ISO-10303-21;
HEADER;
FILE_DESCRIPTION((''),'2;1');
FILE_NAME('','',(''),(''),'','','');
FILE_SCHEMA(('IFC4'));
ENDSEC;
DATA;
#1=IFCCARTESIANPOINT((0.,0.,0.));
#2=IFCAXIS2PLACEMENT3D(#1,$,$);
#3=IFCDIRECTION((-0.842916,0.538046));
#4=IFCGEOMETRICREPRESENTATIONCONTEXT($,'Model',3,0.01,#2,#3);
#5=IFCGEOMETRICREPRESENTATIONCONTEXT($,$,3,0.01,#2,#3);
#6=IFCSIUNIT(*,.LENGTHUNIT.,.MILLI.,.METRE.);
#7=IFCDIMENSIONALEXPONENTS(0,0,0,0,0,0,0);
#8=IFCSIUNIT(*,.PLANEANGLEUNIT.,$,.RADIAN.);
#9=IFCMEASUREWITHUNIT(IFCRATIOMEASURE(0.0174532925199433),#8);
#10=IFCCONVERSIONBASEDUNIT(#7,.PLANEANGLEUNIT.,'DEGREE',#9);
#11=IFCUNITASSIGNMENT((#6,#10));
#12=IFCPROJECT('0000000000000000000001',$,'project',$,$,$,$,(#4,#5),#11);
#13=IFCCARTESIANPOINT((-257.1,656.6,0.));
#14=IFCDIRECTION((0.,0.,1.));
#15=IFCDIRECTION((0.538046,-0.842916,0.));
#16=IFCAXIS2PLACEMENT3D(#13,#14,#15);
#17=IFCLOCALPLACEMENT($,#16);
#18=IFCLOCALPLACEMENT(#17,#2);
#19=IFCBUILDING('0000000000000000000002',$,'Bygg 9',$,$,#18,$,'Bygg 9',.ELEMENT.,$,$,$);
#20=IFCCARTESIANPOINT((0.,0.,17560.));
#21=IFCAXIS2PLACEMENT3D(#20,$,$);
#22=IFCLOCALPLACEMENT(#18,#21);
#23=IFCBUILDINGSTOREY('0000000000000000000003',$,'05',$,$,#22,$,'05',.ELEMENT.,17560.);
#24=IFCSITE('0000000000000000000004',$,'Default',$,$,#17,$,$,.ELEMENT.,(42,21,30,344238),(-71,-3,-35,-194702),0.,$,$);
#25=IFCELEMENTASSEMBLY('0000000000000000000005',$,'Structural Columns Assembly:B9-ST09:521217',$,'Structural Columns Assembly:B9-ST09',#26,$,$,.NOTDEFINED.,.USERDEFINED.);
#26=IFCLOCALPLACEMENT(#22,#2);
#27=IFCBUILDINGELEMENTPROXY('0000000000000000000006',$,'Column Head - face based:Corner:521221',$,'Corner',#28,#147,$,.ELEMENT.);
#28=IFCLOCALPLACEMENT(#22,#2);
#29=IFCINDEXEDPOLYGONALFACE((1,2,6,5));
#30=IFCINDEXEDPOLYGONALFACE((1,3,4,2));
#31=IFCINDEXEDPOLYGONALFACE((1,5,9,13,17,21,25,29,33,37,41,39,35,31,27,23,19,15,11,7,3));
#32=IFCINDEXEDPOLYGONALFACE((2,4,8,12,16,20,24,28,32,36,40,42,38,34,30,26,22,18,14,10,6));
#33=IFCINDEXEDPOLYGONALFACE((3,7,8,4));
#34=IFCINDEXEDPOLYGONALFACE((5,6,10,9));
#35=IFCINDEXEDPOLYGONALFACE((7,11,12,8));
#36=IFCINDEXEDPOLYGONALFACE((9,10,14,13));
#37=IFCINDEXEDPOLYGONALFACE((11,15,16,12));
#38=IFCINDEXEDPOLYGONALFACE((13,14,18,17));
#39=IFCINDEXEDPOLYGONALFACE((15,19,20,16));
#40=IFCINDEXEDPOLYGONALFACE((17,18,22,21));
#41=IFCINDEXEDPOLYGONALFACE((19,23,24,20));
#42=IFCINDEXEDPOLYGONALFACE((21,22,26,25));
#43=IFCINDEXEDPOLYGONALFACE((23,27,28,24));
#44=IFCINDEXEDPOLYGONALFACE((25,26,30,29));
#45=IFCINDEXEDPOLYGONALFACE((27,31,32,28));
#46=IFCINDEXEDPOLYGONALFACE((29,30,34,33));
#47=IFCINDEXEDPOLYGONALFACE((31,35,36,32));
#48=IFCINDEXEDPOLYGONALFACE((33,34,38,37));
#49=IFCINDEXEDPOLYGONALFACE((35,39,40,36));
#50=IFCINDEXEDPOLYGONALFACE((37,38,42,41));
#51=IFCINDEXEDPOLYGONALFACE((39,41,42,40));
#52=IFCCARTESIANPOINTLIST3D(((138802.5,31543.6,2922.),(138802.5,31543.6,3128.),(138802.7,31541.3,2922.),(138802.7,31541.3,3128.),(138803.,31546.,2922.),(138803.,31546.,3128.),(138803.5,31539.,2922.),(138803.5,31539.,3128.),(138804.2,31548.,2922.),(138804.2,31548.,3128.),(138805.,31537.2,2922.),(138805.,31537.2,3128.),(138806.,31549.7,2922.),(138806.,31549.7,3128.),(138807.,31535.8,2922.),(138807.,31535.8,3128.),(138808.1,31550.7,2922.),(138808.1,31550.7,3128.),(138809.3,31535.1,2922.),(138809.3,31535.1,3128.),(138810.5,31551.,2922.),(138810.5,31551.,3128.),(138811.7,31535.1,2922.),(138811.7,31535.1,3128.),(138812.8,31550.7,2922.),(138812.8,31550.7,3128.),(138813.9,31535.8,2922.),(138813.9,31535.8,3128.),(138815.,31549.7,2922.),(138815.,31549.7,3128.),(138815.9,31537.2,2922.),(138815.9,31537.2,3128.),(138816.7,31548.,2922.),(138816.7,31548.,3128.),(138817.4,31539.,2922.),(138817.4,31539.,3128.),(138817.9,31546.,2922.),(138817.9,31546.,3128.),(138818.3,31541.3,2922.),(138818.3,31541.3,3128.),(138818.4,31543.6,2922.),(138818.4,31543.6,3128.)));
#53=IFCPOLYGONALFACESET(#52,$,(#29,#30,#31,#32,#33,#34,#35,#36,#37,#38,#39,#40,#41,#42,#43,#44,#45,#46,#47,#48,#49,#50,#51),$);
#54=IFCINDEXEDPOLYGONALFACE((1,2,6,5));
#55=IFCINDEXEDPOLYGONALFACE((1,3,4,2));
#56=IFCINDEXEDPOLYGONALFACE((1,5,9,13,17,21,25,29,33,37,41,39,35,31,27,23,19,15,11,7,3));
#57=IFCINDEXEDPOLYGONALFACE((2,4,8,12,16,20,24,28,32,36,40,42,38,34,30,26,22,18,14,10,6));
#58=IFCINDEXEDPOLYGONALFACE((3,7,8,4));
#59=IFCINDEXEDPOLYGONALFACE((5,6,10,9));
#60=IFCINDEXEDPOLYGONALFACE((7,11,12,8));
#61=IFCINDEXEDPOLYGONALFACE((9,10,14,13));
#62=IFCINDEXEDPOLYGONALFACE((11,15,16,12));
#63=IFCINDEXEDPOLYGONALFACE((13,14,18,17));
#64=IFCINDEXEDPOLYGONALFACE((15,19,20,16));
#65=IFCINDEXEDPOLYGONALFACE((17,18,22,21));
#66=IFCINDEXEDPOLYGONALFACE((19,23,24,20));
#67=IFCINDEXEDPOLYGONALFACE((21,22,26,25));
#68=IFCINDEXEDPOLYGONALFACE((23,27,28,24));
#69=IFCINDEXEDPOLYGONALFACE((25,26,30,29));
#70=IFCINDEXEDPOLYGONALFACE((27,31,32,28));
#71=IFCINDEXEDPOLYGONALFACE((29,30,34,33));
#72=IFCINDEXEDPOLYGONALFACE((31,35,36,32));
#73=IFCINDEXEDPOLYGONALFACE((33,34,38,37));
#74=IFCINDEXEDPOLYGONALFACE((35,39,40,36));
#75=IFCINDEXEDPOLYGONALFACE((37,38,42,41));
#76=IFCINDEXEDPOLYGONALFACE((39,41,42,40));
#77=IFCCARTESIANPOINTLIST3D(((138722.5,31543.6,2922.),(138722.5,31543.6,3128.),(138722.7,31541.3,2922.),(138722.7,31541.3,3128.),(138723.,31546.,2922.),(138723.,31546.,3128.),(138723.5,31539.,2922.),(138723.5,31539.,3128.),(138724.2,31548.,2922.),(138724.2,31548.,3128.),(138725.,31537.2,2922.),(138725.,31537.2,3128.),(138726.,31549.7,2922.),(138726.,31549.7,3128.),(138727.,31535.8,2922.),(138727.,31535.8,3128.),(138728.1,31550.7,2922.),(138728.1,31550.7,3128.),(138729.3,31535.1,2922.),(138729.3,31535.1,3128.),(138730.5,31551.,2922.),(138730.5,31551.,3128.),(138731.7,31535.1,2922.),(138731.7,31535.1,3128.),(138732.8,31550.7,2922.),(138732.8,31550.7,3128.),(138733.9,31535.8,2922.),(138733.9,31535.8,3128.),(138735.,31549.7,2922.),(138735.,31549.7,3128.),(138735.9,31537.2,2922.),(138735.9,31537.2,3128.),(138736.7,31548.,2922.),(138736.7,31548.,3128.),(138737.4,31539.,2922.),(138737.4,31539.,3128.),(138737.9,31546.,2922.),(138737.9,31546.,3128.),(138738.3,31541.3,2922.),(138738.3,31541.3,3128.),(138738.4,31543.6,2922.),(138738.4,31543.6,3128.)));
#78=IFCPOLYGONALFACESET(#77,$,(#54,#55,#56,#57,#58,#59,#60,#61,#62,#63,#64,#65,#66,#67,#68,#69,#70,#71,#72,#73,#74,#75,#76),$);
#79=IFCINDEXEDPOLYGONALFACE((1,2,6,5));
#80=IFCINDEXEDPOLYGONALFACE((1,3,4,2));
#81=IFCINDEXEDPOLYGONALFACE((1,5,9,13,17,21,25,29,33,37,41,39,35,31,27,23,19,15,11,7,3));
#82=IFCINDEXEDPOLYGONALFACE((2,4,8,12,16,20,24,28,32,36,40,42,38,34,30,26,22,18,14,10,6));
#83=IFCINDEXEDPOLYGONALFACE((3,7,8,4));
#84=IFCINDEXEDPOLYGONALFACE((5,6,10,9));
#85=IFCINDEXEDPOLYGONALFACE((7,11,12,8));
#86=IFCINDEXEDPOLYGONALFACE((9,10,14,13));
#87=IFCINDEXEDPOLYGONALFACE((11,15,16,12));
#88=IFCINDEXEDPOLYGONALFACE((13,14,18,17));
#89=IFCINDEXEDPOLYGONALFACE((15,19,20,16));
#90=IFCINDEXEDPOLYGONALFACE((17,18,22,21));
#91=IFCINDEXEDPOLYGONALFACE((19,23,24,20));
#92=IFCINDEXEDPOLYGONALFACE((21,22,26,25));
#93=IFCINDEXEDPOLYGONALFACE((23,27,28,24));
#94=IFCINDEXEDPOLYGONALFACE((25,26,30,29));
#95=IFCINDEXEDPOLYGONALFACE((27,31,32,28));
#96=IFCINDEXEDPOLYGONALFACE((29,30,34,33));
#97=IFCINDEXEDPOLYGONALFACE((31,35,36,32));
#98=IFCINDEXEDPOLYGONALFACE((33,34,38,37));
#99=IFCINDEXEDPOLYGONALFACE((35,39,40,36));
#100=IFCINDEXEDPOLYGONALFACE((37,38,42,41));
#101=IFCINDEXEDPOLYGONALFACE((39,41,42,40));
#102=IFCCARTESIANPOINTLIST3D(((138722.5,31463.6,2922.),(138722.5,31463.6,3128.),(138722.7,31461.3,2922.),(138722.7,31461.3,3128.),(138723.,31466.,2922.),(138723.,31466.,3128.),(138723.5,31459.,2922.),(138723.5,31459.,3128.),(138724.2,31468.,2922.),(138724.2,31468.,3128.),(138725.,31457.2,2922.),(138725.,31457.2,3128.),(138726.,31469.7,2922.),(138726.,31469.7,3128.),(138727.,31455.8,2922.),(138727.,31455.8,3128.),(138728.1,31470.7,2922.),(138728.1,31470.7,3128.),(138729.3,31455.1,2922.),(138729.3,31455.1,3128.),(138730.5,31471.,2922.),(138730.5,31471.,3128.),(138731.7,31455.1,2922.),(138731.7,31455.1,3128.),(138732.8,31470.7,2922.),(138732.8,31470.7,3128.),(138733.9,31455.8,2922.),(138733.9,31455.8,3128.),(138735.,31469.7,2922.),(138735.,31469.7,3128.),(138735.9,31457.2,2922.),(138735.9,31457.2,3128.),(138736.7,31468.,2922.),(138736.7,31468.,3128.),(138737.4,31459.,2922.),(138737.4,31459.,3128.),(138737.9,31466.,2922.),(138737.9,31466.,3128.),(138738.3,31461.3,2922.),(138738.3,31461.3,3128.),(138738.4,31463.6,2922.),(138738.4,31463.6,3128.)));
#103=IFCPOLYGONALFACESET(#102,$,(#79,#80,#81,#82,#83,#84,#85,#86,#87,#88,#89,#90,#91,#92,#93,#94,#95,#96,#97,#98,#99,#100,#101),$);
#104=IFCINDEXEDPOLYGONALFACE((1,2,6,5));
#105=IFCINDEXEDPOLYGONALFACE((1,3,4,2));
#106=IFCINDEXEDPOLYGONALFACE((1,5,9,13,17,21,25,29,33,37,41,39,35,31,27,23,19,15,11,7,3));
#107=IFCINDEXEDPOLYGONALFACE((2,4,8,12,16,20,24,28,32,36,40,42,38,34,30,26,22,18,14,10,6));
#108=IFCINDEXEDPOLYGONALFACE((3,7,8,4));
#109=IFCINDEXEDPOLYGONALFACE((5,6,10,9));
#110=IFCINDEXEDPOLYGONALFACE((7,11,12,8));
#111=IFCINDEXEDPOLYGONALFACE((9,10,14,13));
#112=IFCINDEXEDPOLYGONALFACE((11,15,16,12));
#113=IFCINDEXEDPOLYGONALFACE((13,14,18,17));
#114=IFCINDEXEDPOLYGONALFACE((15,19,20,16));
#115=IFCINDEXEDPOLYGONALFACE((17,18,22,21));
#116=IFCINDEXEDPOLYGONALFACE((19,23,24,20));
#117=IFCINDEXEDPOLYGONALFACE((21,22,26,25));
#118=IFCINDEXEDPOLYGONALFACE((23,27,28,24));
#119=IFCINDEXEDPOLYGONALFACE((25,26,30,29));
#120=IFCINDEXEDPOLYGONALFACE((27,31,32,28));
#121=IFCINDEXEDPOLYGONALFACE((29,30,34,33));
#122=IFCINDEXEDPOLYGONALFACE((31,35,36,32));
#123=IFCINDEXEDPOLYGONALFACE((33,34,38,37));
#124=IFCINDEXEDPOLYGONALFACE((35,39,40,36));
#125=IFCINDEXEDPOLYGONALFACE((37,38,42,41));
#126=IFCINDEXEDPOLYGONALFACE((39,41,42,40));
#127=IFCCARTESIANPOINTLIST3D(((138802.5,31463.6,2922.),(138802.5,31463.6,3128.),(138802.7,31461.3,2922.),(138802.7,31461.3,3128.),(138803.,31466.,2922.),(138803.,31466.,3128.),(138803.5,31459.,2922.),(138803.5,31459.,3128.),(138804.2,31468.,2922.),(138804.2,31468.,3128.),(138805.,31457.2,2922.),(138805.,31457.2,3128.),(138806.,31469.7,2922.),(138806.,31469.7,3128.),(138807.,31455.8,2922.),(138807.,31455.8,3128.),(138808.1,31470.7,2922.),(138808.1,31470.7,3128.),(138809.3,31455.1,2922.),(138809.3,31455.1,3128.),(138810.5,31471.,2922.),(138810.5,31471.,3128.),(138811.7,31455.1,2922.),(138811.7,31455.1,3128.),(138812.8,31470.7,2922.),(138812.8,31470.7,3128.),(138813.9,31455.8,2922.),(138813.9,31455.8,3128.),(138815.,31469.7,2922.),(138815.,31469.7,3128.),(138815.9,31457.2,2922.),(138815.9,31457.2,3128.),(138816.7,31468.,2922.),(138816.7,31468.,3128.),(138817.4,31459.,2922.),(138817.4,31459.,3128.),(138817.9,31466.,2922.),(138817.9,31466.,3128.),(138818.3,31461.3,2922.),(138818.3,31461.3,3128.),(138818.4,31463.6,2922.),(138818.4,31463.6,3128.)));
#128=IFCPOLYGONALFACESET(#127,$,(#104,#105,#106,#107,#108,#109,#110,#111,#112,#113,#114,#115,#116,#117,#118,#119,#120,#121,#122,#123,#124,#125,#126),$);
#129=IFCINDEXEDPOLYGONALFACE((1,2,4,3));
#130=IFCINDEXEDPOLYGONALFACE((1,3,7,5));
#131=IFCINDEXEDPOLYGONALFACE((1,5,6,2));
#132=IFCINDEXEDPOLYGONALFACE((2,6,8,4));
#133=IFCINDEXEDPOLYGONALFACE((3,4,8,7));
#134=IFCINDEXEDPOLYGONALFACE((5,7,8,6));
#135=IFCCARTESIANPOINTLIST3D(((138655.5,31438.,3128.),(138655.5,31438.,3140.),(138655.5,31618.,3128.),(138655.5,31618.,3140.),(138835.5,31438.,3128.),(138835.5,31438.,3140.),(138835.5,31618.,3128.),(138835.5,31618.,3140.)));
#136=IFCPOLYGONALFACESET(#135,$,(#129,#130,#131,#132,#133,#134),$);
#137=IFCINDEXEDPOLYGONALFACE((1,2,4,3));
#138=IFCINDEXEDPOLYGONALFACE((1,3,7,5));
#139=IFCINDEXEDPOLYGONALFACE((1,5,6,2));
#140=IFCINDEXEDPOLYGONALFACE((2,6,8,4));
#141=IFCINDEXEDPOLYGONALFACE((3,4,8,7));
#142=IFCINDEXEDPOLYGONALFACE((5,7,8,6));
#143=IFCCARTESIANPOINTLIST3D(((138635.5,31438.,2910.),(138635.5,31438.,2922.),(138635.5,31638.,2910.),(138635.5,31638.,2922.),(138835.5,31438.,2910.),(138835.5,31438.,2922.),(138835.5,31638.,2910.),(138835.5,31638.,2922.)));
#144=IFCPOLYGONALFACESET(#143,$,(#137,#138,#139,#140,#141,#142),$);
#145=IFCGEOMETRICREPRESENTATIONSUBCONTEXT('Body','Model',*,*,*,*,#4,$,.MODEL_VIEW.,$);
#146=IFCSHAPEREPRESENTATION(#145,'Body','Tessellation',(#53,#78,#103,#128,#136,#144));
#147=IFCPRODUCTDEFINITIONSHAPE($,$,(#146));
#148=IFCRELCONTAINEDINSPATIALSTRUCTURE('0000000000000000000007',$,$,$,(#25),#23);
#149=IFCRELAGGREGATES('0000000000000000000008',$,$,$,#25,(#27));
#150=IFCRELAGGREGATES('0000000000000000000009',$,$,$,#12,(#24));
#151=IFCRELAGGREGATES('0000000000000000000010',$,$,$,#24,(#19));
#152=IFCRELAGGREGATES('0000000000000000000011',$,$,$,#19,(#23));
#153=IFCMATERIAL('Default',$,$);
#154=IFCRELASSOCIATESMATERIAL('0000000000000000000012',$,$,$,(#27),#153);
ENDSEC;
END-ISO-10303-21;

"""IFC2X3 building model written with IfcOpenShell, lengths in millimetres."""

from ifc_helpers import new_model, entity, si_unit, converted_unit, direction, frame, frame_2d, origin, origin_2d_with_axis, place, context, subcontext, project, spatial, rectangle, circle, extrude, source, transform, mapped, material, element, aggregate, save


model = new_model("IFC2X3")

# Units and contexts
model_context = context("Model", 3, precision=0.01, world=origin(), true_north=direction((-0.842916, 0.538046)))
context_of_model = context(None, 3, precision=0.01, world=origin(), true_north=direction((-0.842916, 0.538046)))
body_context = subcontext(model_context, "Body", "Model", "MODEL_VIEW")
ifc_project = project(units=[si_unit("LENGTHUNIT", "METRE", prefix="MILLI"), converted_unit("PLANEANGLEUNIT", "DEGREE", entity("IfcRatioMeasure", 0.0174532925199433), si_unit("PLANEANGLEUNIT", "RADIAN"), dimensions=[0, 0, 0, 0, 0, 0, 0])], contexts=[model_context, context_of_model])

# Site, building, storey
site_placement = place(None, frame((-257.1, 656.6, 0.0), z_axis=(0.0, 0.0, 1.0), x_axis=(0.538046, -0.842916, 0.0)))
site = spatial("IfcSite", under=ifc_project, at=site_placement, Name="Default", CompositionType="ELEMENT", RefLatitude=(42, 21, 30, 344238), RefLongitude=(-71, -3, -35, -194702), RefElevation=0.0)
building_placement = place(site_placement, origin())
building = spatial("IfcBuilding", under=site, at=building_placement, Name="Bygg 9", LongName="Bygg 9", CompositionType="ELEMENT")
storey_placement = place(building_placement, frame((0.0, 0.0, 17560.0)))
storey = spatial("IfcBuildingStorey", under=building, at=storey_placement, Name="05", LongName="05", CompositionType="ELEMENT", Elevation=17560.0)

# Shared definitions
ifc_material_1 = material(Name="Default")

# Element assembly, building element proxy
assembly_1_placement = place(storey_placement, origin())
assembly_1 = element("IfcElementAssembly", 1, at=assembly_1_placement, inside=storey, Name="Structural Columns Assembly:B9-ST09:521217", ObjectType="Structural Columns Assembly:B9-ST09", AssemblyPlace="NOTDEFINED", PredefinedType="USERDEFINED")
shared_shape_1 = source(origin(), body_context, "Body", "SweptSolid", [
    extrude(circle(Radius=8.0, at=frame_2d((0.0, 0.0), x_axis=(1.0, 0.0))), frame((-55.0, -135.0, 12.0)), (0.0, 0.0, 1.0), 206.0),
    extrude(circle(Radius=8.0, at=frame_2d((0.0, 0.0), x_axis=(1.0, 0.0))), frame((-55.0, -55.0, 12.0)), (0.0, 0.0, 1.0), 206.0),
    extrude(circle(Radius=8.0, at=frame_2d((0.0, 0.0), x_axis=(1.0, 0.0))), frame((-135.0, -55.0, 12.0)), (0.0, 0.0, 1.0), 206.0),
    extrude(circle(Radius=8.0, at=frame_2d((0.0, 0.0), x_axis=(1.0, 0.0))), frame((-135.0, -135.0, 12.0)), (0.0, 0.0, 1.0), 206.0),
    extrude(rectangle(XDim=180.0, YDim=180.0, at=origin_2d_with_axis()), frame((-70.0, -70.0, 218.0), z_axis=(0.0, 0.0, 1.0), x_axis=(-1.0, 0.0, 0.0)), (0.0, 0.0, 1.0), 12.0),
    extrude(rectangle(XDim=200.0, YDim=200.0, at=origin_2d_with_axis()), frame((-60.0, -60.0, 0.0), z_axis=(0.0, 0.0, 1.0), x_axis=(0.0, 1.0, 0.0)), (0.0, 0.0, 1.0), 12.0),
])
proxy_1_placement = place(assembly_1_placement, frame((138675.5, 31598.0, 2910.0), z_axis=(0.0, 0.0, 1.0), x_axis=(0.0, 1.0, 0.0)))
proxy_1 = element("IfcBuildingElementProxy", 2, at=proxy_1_placement, material=ifc_material_1, Name="Column Head - face based:Corner:521221", ObjectType="Corner", CompositionType="ELEMENT", context=body_context, shape_type="MappedRepresentation", body=[
    mapped(shared_shape_1, transform((0.0, 0.0, 0.0), scale=1.0)),
])
aggregate(assembly_1, [proxy_1])

save(model, "model.ifc")
